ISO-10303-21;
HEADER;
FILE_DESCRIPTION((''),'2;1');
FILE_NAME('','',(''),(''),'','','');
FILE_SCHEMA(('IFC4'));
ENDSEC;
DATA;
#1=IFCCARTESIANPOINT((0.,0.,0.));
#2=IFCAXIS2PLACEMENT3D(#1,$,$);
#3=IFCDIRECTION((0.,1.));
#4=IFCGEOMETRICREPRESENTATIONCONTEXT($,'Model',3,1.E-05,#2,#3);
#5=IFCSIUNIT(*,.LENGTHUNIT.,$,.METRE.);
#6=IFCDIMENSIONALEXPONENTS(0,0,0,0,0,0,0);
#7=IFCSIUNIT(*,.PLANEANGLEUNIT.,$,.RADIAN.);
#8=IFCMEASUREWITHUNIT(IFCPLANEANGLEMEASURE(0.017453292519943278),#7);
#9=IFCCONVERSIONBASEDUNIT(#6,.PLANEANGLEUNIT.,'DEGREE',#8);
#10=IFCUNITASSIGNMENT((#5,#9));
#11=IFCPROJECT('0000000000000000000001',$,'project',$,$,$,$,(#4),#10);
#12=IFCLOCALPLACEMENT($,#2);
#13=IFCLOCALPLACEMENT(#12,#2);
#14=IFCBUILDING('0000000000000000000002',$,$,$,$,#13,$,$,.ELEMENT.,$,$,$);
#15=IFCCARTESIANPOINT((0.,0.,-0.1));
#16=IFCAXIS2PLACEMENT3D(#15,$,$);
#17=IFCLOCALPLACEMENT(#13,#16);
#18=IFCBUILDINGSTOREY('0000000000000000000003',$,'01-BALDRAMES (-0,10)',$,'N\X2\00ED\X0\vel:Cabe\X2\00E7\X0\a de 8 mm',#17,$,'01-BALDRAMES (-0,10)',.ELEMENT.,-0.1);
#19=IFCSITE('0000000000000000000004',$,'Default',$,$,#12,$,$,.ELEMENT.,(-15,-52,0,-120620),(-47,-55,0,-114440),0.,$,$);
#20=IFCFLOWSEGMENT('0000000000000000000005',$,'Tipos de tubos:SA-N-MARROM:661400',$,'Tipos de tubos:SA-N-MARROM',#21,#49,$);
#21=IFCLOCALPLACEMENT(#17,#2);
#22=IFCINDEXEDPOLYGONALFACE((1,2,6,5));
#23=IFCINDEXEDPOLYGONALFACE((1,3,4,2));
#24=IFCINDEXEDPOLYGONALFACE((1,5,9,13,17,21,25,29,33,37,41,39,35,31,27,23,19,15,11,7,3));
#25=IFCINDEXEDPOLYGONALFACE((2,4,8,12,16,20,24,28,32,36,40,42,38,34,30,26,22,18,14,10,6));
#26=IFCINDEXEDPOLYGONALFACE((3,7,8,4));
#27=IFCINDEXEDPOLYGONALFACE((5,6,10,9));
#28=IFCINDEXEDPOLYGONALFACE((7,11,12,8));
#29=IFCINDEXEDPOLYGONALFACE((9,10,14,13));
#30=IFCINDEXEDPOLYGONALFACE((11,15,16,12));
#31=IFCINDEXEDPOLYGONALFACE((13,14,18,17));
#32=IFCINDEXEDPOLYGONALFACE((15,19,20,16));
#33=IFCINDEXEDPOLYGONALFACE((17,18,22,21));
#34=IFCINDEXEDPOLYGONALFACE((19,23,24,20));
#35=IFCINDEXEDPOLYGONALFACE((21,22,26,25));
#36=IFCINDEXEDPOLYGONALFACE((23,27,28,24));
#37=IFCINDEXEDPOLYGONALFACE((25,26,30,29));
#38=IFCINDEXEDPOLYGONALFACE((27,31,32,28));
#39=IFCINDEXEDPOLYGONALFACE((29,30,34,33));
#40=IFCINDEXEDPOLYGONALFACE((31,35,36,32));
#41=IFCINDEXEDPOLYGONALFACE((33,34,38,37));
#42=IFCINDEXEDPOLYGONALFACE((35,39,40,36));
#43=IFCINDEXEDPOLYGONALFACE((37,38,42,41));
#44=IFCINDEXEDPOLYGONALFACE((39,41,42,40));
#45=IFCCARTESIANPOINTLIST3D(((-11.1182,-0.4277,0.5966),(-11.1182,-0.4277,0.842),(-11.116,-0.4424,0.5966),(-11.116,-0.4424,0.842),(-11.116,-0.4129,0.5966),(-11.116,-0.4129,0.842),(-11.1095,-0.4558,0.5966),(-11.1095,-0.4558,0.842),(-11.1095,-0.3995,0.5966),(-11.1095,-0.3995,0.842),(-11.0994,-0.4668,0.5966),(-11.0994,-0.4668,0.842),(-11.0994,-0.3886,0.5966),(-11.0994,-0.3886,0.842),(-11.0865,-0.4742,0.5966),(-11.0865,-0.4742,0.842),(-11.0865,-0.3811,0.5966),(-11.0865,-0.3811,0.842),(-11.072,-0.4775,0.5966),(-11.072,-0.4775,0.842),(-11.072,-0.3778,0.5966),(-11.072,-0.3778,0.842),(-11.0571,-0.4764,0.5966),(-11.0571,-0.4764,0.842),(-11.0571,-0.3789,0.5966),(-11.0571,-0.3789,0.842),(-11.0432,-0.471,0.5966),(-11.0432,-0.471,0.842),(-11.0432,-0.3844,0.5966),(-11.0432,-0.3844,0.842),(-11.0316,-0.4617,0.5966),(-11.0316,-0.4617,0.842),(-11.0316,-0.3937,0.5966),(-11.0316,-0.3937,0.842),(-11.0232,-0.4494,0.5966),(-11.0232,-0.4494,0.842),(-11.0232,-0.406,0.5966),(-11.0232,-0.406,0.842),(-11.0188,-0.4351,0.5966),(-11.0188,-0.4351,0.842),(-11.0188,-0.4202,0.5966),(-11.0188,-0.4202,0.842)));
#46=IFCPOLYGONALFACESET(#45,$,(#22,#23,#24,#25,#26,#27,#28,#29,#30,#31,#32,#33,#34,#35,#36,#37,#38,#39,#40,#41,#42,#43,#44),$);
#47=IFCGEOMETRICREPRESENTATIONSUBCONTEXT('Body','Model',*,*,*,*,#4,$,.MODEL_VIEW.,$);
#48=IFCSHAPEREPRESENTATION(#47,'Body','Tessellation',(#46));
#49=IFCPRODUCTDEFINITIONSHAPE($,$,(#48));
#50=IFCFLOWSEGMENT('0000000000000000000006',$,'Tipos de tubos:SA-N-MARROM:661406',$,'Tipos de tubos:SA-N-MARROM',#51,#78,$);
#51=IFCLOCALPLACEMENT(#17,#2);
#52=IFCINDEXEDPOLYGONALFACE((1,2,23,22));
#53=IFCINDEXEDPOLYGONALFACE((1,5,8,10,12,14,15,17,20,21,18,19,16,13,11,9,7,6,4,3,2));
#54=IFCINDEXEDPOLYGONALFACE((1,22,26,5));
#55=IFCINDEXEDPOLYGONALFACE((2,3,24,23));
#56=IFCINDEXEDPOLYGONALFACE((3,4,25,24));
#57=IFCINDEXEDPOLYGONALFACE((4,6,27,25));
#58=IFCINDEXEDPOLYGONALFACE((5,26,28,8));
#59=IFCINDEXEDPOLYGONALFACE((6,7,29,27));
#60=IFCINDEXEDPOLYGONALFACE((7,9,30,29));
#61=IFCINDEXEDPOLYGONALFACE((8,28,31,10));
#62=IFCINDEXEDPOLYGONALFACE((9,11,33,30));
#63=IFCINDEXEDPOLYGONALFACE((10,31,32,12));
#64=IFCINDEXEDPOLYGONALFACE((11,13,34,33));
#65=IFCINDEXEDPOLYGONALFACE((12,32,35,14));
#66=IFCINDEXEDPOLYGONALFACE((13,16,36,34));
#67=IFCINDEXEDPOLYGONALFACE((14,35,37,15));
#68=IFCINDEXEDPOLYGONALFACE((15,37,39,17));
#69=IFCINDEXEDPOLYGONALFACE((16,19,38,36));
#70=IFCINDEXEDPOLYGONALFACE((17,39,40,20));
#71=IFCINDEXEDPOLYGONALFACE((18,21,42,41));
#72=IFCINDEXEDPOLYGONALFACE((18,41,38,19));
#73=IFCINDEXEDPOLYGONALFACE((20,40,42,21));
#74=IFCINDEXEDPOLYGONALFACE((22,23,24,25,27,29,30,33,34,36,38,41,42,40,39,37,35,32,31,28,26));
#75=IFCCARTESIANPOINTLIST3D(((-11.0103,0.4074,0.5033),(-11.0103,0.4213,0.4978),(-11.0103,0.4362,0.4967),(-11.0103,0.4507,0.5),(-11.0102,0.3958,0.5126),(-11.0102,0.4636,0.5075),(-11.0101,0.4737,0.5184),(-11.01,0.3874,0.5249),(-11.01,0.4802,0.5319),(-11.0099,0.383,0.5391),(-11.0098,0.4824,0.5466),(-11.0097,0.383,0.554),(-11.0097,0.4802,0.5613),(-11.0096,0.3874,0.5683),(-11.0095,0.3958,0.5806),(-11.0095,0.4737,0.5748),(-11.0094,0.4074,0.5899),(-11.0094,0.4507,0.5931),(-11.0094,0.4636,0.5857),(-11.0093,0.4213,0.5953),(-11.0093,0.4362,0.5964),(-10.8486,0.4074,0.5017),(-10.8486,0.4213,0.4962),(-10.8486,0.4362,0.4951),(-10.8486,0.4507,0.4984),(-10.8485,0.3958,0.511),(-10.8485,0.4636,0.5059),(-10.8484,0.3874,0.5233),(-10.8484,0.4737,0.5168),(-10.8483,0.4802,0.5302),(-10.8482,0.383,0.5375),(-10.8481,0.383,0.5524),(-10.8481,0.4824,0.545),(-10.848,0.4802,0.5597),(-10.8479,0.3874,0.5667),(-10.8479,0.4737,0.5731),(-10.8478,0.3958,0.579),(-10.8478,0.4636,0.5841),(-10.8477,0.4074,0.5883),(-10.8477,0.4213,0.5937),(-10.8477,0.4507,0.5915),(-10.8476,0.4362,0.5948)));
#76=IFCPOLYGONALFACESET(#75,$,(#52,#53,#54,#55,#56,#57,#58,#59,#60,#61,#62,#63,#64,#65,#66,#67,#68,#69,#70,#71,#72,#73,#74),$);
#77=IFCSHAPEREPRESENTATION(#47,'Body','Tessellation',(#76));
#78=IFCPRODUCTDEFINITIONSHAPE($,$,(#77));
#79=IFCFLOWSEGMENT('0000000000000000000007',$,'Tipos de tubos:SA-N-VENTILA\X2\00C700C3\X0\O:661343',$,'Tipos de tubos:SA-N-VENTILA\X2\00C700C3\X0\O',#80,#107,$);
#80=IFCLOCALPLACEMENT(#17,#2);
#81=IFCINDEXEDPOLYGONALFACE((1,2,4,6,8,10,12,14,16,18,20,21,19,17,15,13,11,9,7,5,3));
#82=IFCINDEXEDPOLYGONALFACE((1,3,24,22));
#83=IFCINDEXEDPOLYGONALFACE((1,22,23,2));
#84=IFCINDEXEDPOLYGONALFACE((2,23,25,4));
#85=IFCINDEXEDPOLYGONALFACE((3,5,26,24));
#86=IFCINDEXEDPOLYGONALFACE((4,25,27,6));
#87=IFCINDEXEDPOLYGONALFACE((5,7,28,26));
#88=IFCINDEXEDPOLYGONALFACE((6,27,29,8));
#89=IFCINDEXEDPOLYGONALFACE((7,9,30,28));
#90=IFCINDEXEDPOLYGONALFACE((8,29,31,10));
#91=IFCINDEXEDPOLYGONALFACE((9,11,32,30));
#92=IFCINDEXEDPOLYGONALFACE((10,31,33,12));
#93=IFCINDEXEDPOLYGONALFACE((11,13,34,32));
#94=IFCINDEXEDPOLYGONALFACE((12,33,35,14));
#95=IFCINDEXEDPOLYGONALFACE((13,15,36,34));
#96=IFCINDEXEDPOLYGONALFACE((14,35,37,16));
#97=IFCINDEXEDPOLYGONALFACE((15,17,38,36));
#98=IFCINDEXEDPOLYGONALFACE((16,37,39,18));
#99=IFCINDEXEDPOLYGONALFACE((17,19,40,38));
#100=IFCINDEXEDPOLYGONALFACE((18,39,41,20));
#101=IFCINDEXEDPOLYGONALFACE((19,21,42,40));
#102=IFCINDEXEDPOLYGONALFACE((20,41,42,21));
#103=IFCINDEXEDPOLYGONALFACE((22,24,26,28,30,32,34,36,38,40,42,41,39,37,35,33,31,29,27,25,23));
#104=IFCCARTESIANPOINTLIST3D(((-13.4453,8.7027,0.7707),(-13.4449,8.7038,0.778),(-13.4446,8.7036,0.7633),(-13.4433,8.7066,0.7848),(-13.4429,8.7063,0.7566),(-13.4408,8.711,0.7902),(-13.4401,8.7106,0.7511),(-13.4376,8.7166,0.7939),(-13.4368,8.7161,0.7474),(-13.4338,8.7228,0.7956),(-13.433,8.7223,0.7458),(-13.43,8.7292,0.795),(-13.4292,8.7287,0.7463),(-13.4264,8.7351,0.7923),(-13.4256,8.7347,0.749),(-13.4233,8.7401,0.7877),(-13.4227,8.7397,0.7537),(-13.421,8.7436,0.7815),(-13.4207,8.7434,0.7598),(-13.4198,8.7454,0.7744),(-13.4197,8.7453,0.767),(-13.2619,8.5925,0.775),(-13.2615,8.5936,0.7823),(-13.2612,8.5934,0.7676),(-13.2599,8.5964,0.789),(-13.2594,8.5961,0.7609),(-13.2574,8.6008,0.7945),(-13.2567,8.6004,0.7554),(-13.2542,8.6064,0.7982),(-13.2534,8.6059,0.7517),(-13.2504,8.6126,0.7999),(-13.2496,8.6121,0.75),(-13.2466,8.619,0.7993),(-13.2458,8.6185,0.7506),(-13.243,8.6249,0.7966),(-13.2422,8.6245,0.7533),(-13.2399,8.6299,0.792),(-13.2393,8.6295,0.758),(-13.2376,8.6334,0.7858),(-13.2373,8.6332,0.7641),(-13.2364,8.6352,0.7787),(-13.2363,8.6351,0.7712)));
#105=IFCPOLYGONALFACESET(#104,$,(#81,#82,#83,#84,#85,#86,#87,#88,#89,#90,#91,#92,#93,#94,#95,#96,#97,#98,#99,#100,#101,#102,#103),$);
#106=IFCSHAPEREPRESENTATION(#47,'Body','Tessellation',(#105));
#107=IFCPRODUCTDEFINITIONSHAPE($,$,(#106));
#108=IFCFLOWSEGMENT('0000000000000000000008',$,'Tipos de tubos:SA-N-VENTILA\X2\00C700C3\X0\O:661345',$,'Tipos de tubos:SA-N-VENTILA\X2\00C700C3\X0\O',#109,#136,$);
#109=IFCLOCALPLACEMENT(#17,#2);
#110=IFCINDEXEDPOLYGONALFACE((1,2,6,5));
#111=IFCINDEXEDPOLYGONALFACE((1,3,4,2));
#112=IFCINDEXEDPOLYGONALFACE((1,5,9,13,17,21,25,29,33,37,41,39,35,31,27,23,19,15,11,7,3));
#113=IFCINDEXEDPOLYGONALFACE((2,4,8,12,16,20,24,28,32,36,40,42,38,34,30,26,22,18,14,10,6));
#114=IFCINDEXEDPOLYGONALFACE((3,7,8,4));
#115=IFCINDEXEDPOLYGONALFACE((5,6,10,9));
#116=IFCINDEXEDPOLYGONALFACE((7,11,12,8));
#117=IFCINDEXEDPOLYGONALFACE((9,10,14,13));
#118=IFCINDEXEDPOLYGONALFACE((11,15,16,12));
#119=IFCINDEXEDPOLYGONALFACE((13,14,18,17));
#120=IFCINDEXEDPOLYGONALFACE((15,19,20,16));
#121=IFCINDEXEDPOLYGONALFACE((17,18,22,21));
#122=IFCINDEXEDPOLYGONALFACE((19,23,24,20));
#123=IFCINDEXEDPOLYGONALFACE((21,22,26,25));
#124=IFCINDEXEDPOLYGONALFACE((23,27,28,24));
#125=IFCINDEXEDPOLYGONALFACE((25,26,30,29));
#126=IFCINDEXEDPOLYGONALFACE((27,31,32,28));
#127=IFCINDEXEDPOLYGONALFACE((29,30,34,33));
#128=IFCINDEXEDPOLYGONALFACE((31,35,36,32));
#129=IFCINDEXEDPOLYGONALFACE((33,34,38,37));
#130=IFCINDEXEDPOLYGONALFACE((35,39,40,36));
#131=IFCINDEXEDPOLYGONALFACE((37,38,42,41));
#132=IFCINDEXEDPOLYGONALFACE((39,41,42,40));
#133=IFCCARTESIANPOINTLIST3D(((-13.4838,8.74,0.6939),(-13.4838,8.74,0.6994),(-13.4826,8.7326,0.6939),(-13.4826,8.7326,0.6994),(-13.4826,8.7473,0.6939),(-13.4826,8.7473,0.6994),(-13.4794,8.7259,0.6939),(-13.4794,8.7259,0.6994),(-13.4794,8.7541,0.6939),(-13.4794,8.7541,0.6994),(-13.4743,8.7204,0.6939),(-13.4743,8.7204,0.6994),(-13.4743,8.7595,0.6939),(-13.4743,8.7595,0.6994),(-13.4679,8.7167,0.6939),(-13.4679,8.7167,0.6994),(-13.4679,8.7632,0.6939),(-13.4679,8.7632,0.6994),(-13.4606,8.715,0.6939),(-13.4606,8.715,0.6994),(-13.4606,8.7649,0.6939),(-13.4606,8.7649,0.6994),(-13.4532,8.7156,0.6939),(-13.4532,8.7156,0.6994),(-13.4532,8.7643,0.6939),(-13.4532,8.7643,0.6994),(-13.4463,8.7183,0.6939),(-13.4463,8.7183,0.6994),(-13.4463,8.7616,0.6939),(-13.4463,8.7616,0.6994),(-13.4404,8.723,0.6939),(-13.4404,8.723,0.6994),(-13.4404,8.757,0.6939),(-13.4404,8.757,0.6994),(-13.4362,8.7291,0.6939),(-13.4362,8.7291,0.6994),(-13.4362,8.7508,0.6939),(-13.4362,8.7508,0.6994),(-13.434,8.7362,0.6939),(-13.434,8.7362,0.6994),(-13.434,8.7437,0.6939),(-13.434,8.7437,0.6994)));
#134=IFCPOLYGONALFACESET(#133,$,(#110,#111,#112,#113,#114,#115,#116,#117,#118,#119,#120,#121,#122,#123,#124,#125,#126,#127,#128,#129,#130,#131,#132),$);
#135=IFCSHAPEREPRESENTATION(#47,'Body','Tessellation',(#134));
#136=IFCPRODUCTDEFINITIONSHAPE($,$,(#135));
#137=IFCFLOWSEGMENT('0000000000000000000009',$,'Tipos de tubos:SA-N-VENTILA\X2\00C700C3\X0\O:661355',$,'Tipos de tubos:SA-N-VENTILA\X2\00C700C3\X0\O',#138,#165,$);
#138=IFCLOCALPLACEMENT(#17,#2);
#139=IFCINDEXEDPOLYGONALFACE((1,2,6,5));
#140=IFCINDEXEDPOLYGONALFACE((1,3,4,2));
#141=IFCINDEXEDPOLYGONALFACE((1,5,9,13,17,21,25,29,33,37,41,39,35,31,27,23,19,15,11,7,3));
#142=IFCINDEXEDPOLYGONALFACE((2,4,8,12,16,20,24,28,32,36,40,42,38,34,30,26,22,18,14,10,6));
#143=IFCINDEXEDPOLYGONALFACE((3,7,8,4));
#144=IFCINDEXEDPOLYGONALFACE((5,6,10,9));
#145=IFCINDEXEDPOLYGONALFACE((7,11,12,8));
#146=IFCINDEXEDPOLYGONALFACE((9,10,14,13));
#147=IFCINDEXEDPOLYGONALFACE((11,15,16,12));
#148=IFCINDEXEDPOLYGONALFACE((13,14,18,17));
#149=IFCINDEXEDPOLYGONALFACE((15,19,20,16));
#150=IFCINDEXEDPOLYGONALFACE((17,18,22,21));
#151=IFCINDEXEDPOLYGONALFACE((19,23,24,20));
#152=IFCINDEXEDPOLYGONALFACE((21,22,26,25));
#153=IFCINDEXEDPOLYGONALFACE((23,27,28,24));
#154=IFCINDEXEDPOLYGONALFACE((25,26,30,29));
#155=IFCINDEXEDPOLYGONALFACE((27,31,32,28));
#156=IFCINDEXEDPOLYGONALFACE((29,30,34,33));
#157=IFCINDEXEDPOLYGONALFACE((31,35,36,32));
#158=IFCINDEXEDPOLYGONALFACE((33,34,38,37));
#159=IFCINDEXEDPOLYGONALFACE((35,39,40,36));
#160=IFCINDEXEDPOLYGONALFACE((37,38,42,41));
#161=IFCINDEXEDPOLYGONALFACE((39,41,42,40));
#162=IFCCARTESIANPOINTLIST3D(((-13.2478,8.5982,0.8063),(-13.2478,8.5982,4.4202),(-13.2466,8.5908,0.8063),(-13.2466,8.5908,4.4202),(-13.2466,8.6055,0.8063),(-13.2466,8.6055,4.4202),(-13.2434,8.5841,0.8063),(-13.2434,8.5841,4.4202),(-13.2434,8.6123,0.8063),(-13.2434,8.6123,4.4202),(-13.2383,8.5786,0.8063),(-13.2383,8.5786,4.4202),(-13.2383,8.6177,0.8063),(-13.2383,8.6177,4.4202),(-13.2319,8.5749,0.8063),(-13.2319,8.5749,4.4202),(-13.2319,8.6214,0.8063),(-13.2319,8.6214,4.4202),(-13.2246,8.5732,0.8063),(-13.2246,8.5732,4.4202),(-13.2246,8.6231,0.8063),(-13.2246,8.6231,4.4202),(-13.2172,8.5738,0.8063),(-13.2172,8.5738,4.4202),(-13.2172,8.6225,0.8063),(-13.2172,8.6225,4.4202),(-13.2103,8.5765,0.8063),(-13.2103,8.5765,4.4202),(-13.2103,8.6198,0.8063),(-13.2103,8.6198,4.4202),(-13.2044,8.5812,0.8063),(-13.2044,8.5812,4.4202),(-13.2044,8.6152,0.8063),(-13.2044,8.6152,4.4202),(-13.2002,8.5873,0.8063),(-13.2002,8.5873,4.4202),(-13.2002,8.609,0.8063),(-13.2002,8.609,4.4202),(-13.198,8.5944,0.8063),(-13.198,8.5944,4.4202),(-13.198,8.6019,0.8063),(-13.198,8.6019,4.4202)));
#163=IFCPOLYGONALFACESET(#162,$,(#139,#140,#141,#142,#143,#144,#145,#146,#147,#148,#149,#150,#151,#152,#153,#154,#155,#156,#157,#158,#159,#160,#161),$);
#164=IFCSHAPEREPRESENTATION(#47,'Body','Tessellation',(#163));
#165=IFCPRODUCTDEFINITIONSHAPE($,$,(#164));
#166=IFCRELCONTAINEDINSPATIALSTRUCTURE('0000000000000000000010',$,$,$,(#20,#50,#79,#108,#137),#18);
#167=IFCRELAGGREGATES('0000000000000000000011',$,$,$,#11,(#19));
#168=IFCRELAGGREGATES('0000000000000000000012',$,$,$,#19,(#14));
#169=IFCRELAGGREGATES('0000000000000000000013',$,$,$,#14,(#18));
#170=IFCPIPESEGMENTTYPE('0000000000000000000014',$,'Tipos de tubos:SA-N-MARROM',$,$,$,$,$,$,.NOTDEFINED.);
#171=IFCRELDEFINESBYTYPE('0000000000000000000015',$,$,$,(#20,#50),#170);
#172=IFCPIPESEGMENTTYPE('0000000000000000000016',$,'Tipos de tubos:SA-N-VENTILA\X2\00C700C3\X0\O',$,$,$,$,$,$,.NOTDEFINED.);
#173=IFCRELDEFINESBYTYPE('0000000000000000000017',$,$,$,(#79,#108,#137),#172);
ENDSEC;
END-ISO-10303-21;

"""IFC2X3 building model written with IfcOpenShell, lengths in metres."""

from ifc_helpers import new_model, entity, si_unit, converted_unit, direction, frame, frame_2d, origin, origin_2d_with_axis, place, context, subcontext, project, spatial, circle, extrude, type_object, element, save


model = new_model("IFC2X3")

# Units and contexts
model_context = context("Model", 3, precision=1e-05, world=origin(), true_north=direction((0.0, 1.0)))
body_context = subcontext(model_context, "Body", "Model", "MODEL_VIEW")
ifc_project = project(units=[si_unit("LENGTHUNIT", "METRE"), converted_unit("PLANEANGLEUNIT", "DEGREE", entity("IfcPlaneAngleMeasure", 0.017453292519943278), si_unit("PLANEANGLEUNIT", "RADIAN"), dimensions=[0, 0, 0, 0, 0, 0, 0])], contexts=[model_context])

# Site, building, storey
site_placement = place(None, origin())
site = spatial("IfcSite", under=ifc_project, at=site_placement, Name="Default", CompositionType="ELEMENT", RefLatitude=(-15, -52, 0, -120620), RefLongitude=(-47, -55, 0, -114440), RefElevation=0.0)
building_placement = place(site_placement, origin())
building = spatial("IfcBuilding", under=site, at=building_placement, CompositionType="ELEMENT")
storey_placement = place(building_placement, frame((0.0, 0.0, -0.1)))
storey = spatial("IfcBuildingStorey", under=building, at=storey_placement, Name="01-BALDRAMES (-0,10)", ObjectType="Nível:Cabeça de 8 mm", LongName="01-BALDRAMES (-0,10)", CompositionType="ELEMENT", Elevation=-0.1)

# Flow segments
pipe_segment_type_1 = type_object("IfcPipeSegmentType", Name="Tipos de tubos:SA-N-MARROM", PredefinedType="NOTDEFINED")
flow_segment_1_placement = place(storey_placement, origin())
element("IfcFlowSegment", 1, at=flow_segment_1_placement, inside=storey, type_object=pipe_segment_type_1, Name="Tipos de tubos:SA-N-MARROM:661400", ObjectType="Tipos de tubos:SA-N-MARROM", context=body_context, shape_type="SweptSolid", body=[
    extrude(circle(Radius=0.05, at=origin_2d_with_axis()), frame((-11.0682, -0.4277, 0.5966), z_axis=(0.0, 0.0, 1.0), x_axis=(-1.0, 0.0, 0.0)), (0.0, 0.0, 1.0), 0.2454),
])
flow_segment_2_placement = place(storey_placement, origin())
element("IfcFlowSegment", 2, at=flow_segment_2_placement, inside=storey, type_object=pipe_segment_type_1, Name="Tipos de tubos:SA-N-MARROM:661406", ObjectType="Tipos de tubos:SA-N-MARROM", context=body_context, shape_type="SweptSolid", body=[
    extrude(circle(Radius=0.05, at=frame_2d((0.0, 0.0), x_axis=(1.0, 0.0))), frame((-11.0098, 0.4324, 0.5466), z_axis=(0.99995, 0.000001, -0.01), x_axis=(-0.000001, 1.0, 0.0)), (0.0, 0.0, 1.0), 0.1617),
])
pipe_segment_type_2 = type_object("IfcPipeSegmentType", Name="Tipos de tubos:SA-N-VENTILAÇÃO", PredefinedType="NOTDEFINED")
flow_segment_3_placement = place(storey_placement, origin())
element("IfcFlowSegment", 3, at=flow_segment_3_placement, inside=storey, type_object=pipe_segment_type_2, Name="Tipos de tubos:SA-N-VENTILAÇÃO:661343", ObjectType="Tipos de tubos:SA-N-VENTILAÇÃO", context=body_context, shape_type="SweptSolid", body=[
    extrude(circle(Radius=0.025, at=frame_2d((0.0, 0.0), x_axis=(1.0, 0.0))), frame((-13.4325, 8.7242, 0.7707), z_axis=(0.856996, -0.514934, 0.019996), x_axis=(-0.515037, -0.857168, 0.0)), (0.0, 0.0, 1.0), 0.214),
])
flow_segment_4_placement = place(storey_placement, origin())
element("IfcFlowSegment", 4, at=flow_segment_4_placement, inside=storey, type_object=pipe_segment_type_2, Name="Tipos de tubos:SA-N-VENTILAÇÃO:661345", ObjectType="Tipos de tubos:SA-N-VENTILAÇÃO", context=body_context, shape_type="SweptSolid", body=[
    extrude(circle(Radius=0.025, at=origin_2d_with_axis()), frame((-13.4588, 8.74, 0.6939), z_axis=(0.0, 0.0, 1.0), x_axis=(-1.0, 0.0, 0.0)), (0.0, 0.0, 1.0), 0.0055),
])
flow_segment_5_placement = place(storey_placement, origin())
element("IfcFlowSegment", 5, at=flow_segment_5_placement, inside=storey, type_object=pipe_segment_type_2, Name="Tipos de tubos:SA-N-VENTILAÇÃO:661355", ObjectType="Tipos de tubos:SA-N-VENTILAÇÃO", context=body_context, shape_type="SweptSolid", body=[
    extrude(circle(Radius=0.025, at=frame_2d((0.0, 0.0), x_axis=(1.0, 0.0))), frame((-13.2228, 8.5982, 0.8063), z_axis=(0.0, 0.0, 1.0), x_axis=(-1.0, 0.0, 0.0)), (0.0, 0.0, 1.0), 3.6139),
])

save(model, "model.ifc")
